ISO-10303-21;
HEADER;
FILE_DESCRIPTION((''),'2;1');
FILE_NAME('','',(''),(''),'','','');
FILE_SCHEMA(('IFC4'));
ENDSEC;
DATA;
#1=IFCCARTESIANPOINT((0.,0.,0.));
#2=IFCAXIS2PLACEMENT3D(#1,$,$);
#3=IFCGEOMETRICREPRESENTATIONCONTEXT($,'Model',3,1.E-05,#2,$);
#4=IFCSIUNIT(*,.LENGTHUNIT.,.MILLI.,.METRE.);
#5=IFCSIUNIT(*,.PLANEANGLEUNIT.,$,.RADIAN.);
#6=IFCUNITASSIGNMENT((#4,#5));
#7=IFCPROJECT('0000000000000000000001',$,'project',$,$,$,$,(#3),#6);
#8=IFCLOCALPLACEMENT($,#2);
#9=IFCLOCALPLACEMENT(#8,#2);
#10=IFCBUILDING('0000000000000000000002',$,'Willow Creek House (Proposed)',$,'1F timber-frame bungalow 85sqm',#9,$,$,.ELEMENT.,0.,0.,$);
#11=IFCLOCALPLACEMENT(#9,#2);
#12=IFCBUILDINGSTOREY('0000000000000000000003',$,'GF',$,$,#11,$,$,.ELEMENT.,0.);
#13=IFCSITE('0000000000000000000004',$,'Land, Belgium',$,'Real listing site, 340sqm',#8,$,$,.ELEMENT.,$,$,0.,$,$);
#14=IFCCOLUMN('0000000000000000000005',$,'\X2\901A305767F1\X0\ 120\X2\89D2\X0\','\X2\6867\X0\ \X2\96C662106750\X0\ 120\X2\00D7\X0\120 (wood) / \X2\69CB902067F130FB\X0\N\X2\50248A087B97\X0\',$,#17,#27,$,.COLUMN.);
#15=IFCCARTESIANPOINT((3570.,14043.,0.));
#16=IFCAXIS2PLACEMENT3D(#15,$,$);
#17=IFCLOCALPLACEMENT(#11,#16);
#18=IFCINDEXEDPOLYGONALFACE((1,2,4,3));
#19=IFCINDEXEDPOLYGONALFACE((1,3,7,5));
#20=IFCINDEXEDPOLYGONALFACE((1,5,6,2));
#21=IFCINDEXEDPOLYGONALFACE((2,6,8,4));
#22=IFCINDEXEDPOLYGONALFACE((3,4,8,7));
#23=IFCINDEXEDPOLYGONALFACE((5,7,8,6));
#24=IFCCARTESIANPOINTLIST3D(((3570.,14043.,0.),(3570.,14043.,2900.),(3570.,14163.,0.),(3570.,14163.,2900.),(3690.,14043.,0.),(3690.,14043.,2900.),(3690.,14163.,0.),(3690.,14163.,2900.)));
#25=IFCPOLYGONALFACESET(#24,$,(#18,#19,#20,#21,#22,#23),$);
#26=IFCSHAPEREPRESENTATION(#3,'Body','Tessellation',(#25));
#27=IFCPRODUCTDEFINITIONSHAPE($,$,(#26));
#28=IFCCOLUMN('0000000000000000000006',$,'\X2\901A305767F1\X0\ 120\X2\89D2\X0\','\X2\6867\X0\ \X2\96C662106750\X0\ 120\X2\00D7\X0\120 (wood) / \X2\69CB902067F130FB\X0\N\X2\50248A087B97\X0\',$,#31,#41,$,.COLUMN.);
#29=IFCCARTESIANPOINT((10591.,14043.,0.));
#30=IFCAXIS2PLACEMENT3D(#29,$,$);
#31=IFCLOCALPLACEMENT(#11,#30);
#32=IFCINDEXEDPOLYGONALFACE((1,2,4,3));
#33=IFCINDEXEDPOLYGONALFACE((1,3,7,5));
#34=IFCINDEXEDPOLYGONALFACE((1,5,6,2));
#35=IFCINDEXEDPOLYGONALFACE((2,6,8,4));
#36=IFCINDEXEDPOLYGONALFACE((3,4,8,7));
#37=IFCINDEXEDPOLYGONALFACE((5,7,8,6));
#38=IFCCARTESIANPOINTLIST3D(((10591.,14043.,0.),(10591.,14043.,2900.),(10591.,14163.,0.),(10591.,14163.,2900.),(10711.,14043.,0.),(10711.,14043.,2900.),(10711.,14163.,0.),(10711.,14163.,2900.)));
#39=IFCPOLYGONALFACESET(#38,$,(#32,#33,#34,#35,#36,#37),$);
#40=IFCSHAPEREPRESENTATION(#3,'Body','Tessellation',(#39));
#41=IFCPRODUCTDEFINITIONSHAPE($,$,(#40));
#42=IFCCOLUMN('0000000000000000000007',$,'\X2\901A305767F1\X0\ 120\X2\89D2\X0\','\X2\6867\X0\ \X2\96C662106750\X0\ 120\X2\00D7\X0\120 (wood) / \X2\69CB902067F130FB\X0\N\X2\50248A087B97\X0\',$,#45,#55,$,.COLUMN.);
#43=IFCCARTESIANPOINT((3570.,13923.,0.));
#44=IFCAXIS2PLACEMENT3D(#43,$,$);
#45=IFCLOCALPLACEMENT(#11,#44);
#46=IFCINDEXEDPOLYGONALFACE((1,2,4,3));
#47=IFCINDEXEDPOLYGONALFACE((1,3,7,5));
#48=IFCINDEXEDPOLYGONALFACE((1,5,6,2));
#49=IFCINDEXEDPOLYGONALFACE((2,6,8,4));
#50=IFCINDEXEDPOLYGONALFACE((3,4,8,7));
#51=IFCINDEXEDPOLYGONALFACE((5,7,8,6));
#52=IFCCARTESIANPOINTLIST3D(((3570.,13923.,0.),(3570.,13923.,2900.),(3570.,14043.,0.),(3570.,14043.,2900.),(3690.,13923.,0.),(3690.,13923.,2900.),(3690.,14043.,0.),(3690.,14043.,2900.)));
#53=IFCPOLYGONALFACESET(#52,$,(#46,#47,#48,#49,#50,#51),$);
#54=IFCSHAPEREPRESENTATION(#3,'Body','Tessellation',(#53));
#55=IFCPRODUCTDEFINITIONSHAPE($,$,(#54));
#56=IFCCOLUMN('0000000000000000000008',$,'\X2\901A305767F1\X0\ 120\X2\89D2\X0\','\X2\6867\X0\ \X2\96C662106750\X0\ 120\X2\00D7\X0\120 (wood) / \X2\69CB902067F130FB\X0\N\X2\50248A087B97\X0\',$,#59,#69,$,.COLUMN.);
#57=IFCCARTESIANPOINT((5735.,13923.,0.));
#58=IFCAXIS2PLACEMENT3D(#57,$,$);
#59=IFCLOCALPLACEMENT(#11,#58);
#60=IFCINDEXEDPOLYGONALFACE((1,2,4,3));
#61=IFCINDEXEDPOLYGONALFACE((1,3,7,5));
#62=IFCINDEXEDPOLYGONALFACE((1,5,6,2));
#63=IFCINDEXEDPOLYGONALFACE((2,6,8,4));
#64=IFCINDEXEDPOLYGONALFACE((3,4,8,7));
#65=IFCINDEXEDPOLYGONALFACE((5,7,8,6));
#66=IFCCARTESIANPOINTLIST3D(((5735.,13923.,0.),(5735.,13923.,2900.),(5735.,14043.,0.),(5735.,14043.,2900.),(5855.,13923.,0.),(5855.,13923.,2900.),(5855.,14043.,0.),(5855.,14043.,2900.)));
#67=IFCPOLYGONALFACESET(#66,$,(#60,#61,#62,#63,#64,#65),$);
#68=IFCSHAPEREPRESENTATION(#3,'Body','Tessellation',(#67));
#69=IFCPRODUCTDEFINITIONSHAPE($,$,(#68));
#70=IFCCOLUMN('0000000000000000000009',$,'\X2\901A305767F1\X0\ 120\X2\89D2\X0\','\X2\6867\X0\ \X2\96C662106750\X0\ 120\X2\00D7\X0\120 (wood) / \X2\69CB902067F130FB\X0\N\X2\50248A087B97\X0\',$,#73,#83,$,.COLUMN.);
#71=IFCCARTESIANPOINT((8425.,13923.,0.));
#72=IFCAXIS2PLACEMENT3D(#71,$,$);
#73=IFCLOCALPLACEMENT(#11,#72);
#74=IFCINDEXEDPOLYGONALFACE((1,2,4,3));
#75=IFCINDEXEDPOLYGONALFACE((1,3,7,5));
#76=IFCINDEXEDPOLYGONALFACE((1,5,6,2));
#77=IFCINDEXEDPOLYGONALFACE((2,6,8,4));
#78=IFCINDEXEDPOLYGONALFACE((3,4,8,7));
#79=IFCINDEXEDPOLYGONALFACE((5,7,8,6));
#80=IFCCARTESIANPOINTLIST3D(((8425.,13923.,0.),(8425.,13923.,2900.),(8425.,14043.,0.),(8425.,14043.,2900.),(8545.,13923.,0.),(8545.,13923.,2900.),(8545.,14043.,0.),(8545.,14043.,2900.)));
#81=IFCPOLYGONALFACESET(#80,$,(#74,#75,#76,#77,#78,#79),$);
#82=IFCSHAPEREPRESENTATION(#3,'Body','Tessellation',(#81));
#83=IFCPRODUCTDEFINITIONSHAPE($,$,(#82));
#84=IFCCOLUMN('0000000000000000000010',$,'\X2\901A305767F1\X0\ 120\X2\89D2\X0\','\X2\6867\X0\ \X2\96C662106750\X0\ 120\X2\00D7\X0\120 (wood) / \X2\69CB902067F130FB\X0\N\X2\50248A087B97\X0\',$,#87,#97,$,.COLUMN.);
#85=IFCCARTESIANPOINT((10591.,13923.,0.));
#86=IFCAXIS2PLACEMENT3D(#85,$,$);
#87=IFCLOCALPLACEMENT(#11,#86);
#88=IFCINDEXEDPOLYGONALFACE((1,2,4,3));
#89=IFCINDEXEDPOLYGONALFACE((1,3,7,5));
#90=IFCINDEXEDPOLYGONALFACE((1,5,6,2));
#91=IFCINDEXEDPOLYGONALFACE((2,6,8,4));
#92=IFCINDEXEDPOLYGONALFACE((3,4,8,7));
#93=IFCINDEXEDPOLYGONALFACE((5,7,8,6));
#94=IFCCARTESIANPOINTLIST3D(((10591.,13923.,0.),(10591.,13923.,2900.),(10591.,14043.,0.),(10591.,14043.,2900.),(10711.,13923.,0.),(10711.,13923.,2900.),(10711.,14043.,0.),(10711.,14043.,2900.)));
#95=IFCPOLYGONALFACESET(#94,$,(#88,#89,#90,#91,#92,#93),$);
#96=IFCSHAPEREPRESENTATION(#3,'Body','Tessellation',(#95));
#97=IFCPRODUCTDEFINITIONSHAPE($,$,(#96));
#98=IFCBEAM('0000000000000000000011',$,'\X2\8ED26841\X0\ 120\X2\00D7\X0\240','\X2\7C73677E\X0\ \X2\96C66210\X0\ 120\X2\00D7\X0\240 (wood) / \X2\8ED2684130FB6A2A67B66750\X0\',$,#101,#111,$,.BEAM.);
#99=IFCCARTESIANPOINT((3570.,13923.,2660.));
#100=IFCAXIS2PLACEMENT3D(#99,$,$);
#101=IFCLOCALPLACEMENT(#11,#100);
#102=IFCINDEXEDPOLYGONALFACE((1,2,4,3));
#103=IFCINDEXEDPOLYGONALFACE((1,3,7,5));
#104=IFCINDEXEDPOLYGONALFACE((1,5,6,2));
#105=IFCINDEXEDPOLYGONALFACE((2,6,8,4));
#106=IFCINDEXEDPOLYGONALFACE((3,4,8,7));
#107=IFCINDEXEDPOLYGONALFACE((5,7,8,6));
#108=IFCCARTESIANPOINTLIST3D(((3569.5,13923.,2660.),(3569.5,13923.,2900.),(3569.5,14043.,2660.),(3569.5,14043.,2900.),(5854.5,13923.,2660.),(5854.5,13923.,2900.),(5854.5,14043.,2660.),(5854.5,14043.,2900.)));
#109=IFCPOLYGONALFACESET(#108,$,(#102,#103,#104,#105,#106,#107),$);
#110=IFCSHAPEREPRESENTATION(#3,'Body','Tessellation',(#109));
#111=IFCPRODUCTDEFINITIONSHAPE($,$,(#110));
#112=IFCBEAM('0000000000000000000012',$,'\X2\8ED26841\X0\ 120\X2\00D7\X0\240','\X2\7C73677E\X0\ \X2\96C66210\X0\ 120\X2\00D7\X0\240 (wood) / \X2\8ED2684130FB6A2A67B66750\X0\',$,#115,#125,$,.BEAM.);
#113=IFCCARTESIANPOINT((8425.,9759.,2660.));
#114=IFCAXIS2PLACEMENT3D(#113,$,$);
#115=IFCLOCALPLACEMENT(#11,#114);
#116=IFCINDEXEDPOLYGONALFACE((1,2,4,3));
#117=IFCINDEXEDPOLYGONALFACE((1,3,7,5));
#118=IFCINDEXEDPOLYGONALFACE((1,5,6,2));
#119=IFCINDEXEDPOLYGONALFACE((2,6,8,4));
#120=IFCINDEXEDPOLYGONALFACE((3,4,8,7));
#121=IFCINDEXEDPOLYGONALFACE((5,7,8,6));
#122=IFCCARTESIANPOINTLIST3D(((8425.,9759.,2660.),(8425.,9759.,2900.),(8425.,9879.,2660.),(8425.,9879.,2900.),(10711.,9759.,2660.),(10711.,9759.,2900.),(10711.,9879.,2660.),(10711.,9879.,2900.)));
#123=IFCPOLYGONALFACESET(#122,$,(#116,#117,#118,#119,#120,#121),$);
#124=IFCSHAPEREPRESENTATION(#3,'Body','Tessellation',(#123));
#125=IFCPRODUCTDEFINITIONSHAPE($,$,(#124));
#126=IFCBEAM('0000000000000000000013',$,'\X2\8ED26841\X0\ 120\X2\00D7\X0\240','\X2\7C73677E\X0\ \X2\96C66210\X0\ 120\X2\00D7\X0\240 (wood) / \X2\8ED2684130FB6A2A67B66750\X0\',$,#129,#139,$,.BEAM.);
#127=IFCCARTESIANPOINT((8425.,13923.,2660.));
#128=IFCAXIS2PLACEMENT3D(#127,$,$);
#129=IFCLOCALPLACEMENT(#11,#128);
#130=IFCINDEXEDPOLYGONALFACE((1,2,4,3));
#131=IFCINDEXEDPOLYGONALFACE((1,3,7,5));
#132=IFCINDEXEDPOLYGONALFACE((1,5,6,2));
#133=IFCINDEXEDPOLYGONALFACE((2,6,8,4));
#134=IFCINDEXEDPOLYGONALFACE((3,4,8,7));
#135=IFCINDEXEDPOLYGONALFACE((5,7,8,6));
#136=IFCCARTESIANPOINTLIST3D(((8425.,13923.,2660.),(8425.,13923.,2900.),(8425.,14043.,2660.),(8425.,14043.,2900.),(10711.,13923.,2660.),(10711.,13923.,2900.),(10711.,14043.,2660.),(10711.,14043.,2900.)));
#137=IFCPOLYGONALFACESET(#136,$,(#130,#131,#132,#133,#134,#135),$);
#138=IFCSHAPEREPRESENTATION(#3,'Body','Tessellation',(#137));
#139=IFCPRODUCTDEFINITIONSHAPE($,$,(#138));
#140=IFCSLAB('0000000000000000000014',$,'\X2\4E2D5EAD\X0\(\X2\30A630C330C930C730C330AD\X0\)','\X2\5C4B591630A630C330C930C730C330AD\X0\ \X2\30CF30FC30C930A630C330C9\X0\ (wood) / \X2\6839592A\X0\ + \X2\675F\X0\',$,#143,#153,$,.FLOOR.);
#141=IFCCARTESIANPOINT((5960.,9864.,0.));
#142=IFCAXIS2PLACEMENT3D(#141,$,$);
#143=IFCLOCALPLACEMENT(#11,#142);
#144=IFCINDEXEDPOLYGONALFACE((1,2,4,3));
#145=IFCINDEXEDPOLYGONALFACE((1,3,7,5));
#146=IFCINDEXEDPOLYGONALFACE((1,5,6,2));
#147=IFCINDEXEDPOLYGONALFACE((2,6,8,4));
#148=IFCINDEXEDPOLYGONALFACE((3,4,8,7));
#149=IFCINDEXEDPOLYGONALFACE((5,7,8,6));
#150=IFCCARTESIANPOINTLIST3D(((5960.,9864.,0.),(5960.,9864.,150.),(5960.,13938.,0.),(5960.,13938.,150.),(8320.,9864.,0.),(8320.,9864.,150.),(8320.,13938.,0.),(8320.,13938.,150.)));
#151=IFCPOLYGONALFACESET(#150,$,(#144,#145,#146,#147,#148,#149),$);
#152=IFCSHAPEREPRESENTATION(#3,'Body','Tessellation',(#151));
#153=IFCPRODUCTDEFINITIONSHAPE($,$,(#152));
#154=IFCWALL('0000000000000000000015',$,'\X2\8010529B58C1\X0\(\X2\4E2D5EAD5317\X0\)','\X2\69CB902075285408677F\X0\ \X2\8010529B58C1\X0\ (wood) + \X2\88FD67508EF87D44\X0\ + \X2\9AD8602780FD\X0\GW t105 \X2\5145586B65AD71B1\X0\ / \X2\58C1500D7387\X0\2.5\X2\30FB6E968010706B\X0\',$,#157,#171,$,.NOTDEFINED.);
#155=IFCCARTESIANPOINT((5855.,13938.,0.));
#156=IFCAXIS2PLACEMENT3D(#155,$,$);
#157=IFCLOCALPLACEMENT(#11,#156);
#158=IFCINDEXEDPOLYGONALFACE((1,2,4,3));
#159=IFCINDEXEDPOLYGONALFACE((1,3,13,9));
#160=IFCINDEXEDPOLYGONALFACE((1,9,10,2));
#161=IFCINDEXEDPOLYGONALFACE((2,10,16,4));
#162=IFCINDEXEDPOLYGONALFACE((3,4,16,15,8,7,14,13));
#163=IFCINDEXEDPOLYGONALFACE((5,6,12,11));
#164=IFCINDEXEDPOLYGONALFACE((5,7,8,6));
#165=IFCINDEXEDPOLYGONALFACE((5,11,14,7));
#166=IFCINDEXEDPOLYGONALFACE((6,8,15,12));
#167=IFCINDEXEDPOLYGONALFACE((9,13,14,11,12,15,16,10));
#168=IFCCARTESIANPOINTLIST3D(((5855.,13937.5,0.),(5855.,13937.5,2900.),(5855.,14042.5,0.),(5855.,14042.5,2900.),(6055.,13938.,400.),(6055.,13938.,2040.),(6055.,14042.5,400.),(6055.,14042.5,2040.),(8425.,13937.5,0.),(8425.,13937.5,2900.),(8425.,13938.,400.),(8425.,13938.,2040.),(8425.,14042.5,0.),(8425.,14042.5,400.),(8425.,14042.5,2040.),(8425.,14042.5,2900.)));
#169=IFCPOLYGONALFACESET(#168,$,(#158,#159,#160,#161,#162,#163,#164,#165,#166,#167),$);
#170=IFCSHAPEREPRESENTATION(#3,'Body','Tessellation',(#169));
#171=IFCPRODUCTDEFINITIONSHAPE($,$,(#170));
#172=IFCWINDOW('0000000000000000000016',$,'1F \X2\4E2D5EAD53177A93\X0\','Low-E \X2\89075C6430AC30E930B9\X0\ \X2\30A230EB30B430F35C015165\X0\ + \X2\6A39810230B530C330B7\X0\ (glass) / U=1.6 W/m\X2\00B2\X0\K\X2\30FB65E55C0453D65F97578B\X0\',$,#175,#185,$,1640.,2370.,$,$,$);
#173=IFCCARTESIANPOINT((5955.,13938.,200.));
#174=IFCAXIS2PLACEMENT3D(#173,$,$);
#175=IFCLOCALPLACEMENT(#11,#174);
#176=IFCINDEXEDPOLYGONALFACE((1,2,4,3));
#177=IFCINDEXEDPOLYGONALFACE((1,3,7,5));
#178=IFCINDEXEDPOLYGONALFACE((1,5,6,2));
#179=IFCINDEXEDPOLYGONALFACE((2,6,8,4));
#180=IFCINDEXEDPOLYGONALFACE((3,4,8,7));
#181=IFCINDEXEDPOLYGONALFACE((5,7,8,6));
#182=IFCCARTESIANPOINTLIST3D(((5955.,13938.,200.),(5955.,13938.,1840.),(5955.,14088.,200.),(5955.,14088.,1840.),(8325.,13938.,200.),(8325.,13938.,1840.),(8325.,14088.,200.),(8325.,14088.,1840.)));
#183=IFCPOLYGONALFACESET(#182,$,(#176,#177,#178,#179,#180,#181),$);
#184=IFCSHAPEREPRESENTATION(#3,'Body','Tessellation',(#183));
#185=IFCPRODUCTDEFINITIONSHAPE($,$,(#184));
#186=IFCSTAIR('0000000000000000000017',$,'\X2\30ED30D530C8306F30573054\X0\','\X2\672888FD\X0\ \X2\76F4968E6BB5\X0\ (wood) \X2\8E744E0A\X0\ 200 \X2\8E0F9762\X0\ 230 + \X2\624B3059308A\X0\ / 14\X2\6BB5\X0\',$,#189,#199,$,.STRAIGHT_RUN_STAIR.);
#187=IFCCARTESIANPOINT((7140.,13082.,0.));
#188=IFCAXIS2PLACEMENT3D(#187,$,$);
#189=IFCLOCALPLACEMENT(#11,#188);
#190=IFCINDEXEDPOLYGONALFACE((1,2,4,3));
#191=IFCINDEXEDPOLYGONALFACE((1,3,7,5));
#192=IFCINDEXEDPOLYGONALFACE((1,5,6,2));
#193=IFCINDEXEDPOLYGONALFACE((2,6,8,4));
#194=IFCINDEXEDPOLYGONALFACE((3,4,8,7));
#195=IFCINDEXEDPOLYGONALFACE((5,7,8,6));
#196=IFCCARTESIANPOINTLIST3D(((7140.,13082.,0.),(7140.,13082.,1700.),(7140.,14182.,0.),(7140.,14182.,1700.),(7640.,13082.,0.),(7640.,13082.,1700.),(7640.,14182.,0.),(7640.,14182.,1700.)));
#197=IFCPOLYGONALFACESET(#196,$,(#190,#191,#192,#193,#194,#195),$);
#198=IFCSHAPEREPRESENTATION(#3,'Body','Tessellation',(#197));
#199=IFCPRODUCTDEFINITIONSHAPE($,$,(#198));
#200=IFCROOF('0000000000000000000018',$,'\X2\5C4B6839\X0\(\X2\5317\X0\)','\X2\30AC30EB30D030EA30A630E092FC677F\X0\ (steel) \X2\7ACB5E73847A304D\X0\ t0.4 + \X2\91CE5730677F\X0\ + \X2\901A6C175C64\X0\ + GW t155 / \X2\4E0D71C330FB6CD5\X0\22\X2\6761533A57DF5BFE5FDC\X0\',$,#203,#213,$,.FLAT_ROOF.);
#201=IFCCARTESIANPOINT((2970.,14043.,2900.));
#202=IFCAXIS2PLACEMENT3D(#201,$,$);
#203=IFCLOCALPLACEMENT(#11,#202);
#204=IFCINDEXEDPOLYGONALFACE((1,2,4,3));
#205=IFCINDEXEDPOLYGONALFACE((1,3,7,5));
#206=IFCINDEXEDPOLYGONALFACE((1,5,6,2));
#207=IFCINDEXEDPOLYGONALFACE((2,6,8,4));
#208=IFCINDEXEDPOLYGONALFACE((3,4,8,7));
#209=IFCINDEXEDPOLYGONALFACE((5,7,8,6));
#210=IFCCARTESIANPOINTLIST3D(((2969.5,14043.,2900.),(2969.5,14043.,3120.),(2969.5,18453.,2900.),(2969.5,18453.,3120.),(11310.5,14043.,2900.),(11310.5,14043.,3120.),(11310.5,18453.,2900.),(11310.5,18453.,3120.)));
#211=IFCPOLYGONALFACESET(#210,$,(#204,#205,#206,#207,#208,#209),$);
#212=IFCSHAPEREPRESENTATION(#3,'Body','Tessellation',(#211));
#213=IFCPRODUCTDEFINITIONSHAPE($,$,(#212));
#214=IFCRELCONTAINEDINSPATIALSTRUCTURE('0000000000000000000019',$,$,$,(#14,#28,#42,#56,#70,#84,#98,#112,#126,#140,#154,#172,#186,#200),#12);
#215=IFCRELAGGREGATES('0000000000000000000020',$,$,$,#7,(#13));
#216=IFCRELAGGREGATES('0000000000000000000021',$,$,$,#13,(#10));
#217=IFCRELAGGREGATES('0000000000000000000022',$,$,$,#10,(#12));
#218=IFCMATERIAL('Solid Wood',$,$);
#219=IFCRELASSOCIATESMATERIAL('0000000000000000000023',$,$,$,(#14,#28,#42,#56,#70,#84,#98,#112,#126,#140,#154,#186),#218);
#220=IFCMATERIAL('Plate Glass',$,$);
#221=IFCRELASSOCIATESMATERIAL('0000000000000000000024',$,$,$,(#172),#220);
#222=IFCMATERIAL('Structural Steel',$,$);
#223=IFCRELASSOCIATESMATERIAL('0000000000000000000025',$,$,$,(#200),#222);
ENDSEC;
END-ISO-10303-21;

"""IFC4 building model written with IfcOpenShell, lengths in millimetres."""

from ifc_helpers import new_model, si_unit, frame, frame_2d, origin, place, context, project, spatial, rectangle, extrude, material, element, fill, save


model = new_model("IFC4")

# Units and contexts
model_context = context("Model", 3, precision=1e-05, world=origin())
ifc_project = project(units=[si_unit("LENGTHUNIT", "METRE", prefix="MILLI"), si_unit("PLANEANGLEUNIT", "RADIAN")], contexts=[model_context])

# Site, building, storey
site_placement = place(None, origin())
site = spatial("IfcSite", under=ifc_project, at=site_placement, Name="Land, Belgium", ObjectType="Real listing site, 340sqm", CompositionType="ELEMENT", RefElevation=0.0)
building_placement = place(site_placement, origin())
building = spatial("IfcBuilding", under=site, at=building_placement, Name="Willow Creek House (Proposed)", ObjectType="1F timber-frame bungalow 85sqm", CompositionType="ELEMENT", ElevationOfRefHeight=0.0, ElevationOfTerrain=0.0)
storey_placement = place(building_placement, origin())
storey = spatial("IfcBuildingStorey", under=building, at=storey_placement, Name="GF", CompositionType="ELEMENT", Elevation=0.0)

# Columns
ifc_material_1 = material(Name="Solid Wood")
column_1_placement = place(storey_placement, frame((3570.0, 14043.0, 0.0)))
element("IfcColumn", 1, at=column_1_placement, inside=storey, material=ifc_material_1, Name="通し柱 120角", Description="桧 集成材 120×120 (wood) / 構造柱・N値計算", PredefinedType="COLUMN", context=model_context, shape_type="SweptSolid", body=[
    extrude(rectangle(XDim=120.0, YDim=120.0, at=frame_2d((60.0, 60.0))), frame((3570.0, 14043.0, 0.0)), (0.0, 0.0, 1.0), 2900.0),
])
column_2_placement = place(storey_placement, frame((10591.0, 14043.0, 0.0)))
element("IfcColumn", 2, at=column_2_placement, inside=storey, material=ifc_material_1, Name="通し柱 120角", Description="桧 集成材 120×120 (wood) / 構造柱・N値計算", PredefinedType="COLUMN", context=model_context, shape_type="SweptSolid", body=[
    extrude(rectangle(XDim=120.0, YDim=120.0, at=frame_2d((60.0, 60.0))), frame((10591.0, 14043.0, 0.0)), (0.0, 0.0, 1.0), 2900.0),
])
column_3_placement = place(storey_placement, frame((3570.0, 13923.0, 0.0)))
element("IfcColumn", 3, at=column_3_placement, inside=storey, material=ifc_material_1, Name="通し柱 120角", Description="桧 集成材 120×120 (wood) / 構造柱・N値計算", PredefinedType="COLUMN", context=model_context, shape_type="SweptSolid", body=[
    extrude(rectangle(XDim=120.0, YDim=120.0, at=frame_2d((60.0, 60.0))), frame((3570.0, 13923.0, 0.0)), (0.0, 0.0, 1.0), 2900.0),
])
column_4_placement = place(storey_placement, frame((5735.0, 13923.0, 0.0)))
element("IfcColumn", 4, at=column_4_placement, inside=storey, material=ifc_material_1, Name="通し柱 120角", Description="桧 集成材 120×120 (wood) / 構造柱・N値計算", PredefinedType="COLUMN", context=model_context, shape_type="SweptSolid", body=[
    extrude(rectangle(XDim=120.0, YDim=120.0, at=frame_2d((60.0, 60.0))), frame((5735.0, 13923.0, 0.0)), (0.0, 0.0, 1.0), 2900.0),
])
column_5_placement = place(storey_placement, frame((8425.0, 13923.0, 0.0)))
element("IfcColumn", 5, at=column_5_placement, inside=storey, material=ifc_material_1, Name="通し柱 120角", Description="桧 集成材 120×120 (wood) / 構造柱・N値計算", PredefinedType="COLUMN", context=model_context, shape_type="SweptSolid", body=[
    extrude(rectangle(XDim=120.0, YDim=120.0, at=frame_2d((60.0, 60.0))), frame((8425.0, 13923.0, 0.0)), (0.0, 0.0, 1.0), 2900.0),
])
column_6_placement = place(storey_placement, frame((10591.0, 13923.0, 0.0)))
element("IfcColumn", 6, at=column_6_placement, inside=storey, material=ifc_material_1, Name="通し柱 120角", Description="桧 集成材 120×120 (wood) / 構造柱・N値計算", PredefinedType="COLUMN", context=model_context, shape_type="SweptSolid", body=[
    extrude(rectangle(XDim=120.0, YDim=120.0, at=frame_2d((60.0, 60.0))), frame((10591.0, 13923.0, 0.0)), (0.0, 0.0, 1.0), 2900.0),
])

# Beams
beam_1_placement = place(storey_placement, frame((3570.0, 13923.0, 2660.0)))
element("IfcBeam", 7, at=beam_1_placement, inside=storey, material=ifc_material_1, Name="軒桁 120×240", Description="米松 集成 120×240 (wood) / 軒桁・横架材", PredefinedType="BEAM", context=model_context, shape_type="SweptSolid", body=[
    extrude(rectangle(XDim=2285.0, YDim=120.0, at=frame_2d((1142.0, 60.0))), frame((3570.0, 13923.0, 2660.0)), (0.0, 0.0, 1.0), 240.0),
])
beam_2_placement = place(storey_placement, frame((8425.0, 9759.0, 2660.0)))
element("IfcBeam", 8, at=beam_2_placement, inside=storey, material=ifc_material_1, Name="軒桁 120×240", Description="米松 集成 120×240 (wood) / 軒桁・横架材", PredefinedType="BEAM", context=model_context, shape_type="SweptSolid", body=[
    extrude(rectangle(XDim=2286.0, YDim=120.0, at=frame_2d((1143.0, 60.0))), frame((8425.0, 9759.0, 2660.0)), (0.0, 0.0, 1.0), 240.0),
])
beam_3_placement = place(storey_placement, frame((8425.0, 13923.0, 2660.0)))
element("IfcBeam", 9, at=beam_3_placement, inside=storey, material=ifc_material_1, Name="軒桁 120×240", Description="米松 集成 120×240 (wood) / 軒桁・横架材", PredefinedType="BEAM", context=model_context, shape_type="SweptSolid", body=[
    extrude(rectangle(XDim=2286.0, YDim=120.0, at=frame_2d((1143.0, 60.0))), frame((8425.0, 13923.0, 2660.0)), (0.0, 0.0, 1.0), 240.0),
])

# Slab
slab_1_placement = place(storey_placement, frame((5960.0, 9864.0, 0.0)))
element("IfcSlab", 10, at=slab_1_placement, inside=storey, material=ifc_material_1, Name="中庭(ウッドデッキ)", Description="屋外ウッドデッキ ハードウッド (wood) / 根太 + 束", PredefinedType="FLOOR", context=model_context, shape_type="SweptSolid", body=[
    extrude(rectangle(XDim=2360.0, YDim=4074.0, at=frame_2d((1180.0, 2037.0))), frame((5960.0, 9864.0, 0.0)), (0.0, 0.0, 1.0), 150.0),
])

# Wall, opening, window
wall_placement = place(storey_placement, frame((5855.0, 13938.0, 0.0)))
wall = element("IfcWall", 11, at=wall_placement, inside=storey, material=ifc_material_1, Name="耐力壁(中庭北)", Description="構造用合板 耐力壁 (wood) + 製材軸組 + 高性能GW t105 充填断熱 / 壁倍率2.5・準耐火", PredefinedType="NOTDEFINED", context=model_context, shape_type="SweptSolid", body=[
    extrude(rectangle(XDim=2570.0, YDim=105.0, at=frame_2d((1285.0, 52.0))), frame((5855.0, 13938.0, 0.0)), (0.0, 0.0, 1.0), 2900.0),
])
opening_placement = place(storey_placement, frame((5955.0, 13938.0, 200.0)))
opening = element("IfcOpeningElement", 12, at=opening_placement, cuts=wall, PredefinedType="NOTDEFINED", context=model_context, shape_type="SweptSolid", body=[
    extrude(rectangle(XDim=2370.0, YDim=150.0, at=frame_2d((1185.0, 75.0))), frame((5955.0, 13938.0, 200.0)), (0.0, 0.0, 1.0), 1640.0),
])
ifc_material_2 = material(Name="Plate Glass")
window_placement = place(storey_placement, frame((5955.0, 13938.0, 200.0)))
window = element("IfcWindow", 13, at=window_placement, inside=storey, material=ifc_material_2, Name="1F 中庭北窓", Description="Low-E 複層ガラス アルゴン封入 + 樹脂サッシ (glass) / U=1.6 W/m²K・日射取得型", OverallHeight=1640.0, OverallWidth=2370.0, context=model_context, shape_type="SweptSolid", body=[
    extrude(rectangle(XDim=2370.0, YDim=150.0, at=frame_2d((1185.0, 75.0))), frame((5955.0, 13938.0, 200.0)), (0.0, 0.0, 1.0), 1640.0),
])
fill(opening, window)

# Stair
stair_placement = place(storey_placement, frame((7140.0, 13082.0, 0.0)))
element("IfcStair", 14, at=stair_placement, inside=storey, material=ifc_material_1, Name="ロフトはしご", Description="木製 直階段 (wood) 蹴上 200 踏面 230 + 手すり / 14段", PredefinedType="STRAIGHT_RUN_STAIR", context=model_context, shape_type="SweptSolid", body=[
    extrude(rectangle(XDim=500.0, YDim=1100.0, at=frame_2d((250.0, 550.0))), frame((7140.0, 13082.0, 0.0)), (0.0, 0.0, 1.0), 1700.0),
])

# Roof
ifc_material_3 = material(Name="Structural Steel")
roof_placement = place(storey_placement, frame((2970.0, 14043.0, 2900.0)))
element("IfcRoof", 15, at=roof_placement, inside=storey, material=ifc_material_3, Name="屋根(北)", Description="ガルバリウム鋼板 (steel) 立平葺き t0.4 + 野地板 + 通気層 + GW t155 / 不燃・法22条区域対応", PredefinedType="FLAT_ROOF", context=model_context, shape_type="SweptSolid", body=[
    extrude(rectangle(XDim=8341.0, YDim=4410.0, at=frame_2d((4170.0, 2205.0))), frame((2970.0, 14043.0, 2900.0)), (0.0, 0.0, 1.0), 220.0),
])

save(model, "model.ifc")
